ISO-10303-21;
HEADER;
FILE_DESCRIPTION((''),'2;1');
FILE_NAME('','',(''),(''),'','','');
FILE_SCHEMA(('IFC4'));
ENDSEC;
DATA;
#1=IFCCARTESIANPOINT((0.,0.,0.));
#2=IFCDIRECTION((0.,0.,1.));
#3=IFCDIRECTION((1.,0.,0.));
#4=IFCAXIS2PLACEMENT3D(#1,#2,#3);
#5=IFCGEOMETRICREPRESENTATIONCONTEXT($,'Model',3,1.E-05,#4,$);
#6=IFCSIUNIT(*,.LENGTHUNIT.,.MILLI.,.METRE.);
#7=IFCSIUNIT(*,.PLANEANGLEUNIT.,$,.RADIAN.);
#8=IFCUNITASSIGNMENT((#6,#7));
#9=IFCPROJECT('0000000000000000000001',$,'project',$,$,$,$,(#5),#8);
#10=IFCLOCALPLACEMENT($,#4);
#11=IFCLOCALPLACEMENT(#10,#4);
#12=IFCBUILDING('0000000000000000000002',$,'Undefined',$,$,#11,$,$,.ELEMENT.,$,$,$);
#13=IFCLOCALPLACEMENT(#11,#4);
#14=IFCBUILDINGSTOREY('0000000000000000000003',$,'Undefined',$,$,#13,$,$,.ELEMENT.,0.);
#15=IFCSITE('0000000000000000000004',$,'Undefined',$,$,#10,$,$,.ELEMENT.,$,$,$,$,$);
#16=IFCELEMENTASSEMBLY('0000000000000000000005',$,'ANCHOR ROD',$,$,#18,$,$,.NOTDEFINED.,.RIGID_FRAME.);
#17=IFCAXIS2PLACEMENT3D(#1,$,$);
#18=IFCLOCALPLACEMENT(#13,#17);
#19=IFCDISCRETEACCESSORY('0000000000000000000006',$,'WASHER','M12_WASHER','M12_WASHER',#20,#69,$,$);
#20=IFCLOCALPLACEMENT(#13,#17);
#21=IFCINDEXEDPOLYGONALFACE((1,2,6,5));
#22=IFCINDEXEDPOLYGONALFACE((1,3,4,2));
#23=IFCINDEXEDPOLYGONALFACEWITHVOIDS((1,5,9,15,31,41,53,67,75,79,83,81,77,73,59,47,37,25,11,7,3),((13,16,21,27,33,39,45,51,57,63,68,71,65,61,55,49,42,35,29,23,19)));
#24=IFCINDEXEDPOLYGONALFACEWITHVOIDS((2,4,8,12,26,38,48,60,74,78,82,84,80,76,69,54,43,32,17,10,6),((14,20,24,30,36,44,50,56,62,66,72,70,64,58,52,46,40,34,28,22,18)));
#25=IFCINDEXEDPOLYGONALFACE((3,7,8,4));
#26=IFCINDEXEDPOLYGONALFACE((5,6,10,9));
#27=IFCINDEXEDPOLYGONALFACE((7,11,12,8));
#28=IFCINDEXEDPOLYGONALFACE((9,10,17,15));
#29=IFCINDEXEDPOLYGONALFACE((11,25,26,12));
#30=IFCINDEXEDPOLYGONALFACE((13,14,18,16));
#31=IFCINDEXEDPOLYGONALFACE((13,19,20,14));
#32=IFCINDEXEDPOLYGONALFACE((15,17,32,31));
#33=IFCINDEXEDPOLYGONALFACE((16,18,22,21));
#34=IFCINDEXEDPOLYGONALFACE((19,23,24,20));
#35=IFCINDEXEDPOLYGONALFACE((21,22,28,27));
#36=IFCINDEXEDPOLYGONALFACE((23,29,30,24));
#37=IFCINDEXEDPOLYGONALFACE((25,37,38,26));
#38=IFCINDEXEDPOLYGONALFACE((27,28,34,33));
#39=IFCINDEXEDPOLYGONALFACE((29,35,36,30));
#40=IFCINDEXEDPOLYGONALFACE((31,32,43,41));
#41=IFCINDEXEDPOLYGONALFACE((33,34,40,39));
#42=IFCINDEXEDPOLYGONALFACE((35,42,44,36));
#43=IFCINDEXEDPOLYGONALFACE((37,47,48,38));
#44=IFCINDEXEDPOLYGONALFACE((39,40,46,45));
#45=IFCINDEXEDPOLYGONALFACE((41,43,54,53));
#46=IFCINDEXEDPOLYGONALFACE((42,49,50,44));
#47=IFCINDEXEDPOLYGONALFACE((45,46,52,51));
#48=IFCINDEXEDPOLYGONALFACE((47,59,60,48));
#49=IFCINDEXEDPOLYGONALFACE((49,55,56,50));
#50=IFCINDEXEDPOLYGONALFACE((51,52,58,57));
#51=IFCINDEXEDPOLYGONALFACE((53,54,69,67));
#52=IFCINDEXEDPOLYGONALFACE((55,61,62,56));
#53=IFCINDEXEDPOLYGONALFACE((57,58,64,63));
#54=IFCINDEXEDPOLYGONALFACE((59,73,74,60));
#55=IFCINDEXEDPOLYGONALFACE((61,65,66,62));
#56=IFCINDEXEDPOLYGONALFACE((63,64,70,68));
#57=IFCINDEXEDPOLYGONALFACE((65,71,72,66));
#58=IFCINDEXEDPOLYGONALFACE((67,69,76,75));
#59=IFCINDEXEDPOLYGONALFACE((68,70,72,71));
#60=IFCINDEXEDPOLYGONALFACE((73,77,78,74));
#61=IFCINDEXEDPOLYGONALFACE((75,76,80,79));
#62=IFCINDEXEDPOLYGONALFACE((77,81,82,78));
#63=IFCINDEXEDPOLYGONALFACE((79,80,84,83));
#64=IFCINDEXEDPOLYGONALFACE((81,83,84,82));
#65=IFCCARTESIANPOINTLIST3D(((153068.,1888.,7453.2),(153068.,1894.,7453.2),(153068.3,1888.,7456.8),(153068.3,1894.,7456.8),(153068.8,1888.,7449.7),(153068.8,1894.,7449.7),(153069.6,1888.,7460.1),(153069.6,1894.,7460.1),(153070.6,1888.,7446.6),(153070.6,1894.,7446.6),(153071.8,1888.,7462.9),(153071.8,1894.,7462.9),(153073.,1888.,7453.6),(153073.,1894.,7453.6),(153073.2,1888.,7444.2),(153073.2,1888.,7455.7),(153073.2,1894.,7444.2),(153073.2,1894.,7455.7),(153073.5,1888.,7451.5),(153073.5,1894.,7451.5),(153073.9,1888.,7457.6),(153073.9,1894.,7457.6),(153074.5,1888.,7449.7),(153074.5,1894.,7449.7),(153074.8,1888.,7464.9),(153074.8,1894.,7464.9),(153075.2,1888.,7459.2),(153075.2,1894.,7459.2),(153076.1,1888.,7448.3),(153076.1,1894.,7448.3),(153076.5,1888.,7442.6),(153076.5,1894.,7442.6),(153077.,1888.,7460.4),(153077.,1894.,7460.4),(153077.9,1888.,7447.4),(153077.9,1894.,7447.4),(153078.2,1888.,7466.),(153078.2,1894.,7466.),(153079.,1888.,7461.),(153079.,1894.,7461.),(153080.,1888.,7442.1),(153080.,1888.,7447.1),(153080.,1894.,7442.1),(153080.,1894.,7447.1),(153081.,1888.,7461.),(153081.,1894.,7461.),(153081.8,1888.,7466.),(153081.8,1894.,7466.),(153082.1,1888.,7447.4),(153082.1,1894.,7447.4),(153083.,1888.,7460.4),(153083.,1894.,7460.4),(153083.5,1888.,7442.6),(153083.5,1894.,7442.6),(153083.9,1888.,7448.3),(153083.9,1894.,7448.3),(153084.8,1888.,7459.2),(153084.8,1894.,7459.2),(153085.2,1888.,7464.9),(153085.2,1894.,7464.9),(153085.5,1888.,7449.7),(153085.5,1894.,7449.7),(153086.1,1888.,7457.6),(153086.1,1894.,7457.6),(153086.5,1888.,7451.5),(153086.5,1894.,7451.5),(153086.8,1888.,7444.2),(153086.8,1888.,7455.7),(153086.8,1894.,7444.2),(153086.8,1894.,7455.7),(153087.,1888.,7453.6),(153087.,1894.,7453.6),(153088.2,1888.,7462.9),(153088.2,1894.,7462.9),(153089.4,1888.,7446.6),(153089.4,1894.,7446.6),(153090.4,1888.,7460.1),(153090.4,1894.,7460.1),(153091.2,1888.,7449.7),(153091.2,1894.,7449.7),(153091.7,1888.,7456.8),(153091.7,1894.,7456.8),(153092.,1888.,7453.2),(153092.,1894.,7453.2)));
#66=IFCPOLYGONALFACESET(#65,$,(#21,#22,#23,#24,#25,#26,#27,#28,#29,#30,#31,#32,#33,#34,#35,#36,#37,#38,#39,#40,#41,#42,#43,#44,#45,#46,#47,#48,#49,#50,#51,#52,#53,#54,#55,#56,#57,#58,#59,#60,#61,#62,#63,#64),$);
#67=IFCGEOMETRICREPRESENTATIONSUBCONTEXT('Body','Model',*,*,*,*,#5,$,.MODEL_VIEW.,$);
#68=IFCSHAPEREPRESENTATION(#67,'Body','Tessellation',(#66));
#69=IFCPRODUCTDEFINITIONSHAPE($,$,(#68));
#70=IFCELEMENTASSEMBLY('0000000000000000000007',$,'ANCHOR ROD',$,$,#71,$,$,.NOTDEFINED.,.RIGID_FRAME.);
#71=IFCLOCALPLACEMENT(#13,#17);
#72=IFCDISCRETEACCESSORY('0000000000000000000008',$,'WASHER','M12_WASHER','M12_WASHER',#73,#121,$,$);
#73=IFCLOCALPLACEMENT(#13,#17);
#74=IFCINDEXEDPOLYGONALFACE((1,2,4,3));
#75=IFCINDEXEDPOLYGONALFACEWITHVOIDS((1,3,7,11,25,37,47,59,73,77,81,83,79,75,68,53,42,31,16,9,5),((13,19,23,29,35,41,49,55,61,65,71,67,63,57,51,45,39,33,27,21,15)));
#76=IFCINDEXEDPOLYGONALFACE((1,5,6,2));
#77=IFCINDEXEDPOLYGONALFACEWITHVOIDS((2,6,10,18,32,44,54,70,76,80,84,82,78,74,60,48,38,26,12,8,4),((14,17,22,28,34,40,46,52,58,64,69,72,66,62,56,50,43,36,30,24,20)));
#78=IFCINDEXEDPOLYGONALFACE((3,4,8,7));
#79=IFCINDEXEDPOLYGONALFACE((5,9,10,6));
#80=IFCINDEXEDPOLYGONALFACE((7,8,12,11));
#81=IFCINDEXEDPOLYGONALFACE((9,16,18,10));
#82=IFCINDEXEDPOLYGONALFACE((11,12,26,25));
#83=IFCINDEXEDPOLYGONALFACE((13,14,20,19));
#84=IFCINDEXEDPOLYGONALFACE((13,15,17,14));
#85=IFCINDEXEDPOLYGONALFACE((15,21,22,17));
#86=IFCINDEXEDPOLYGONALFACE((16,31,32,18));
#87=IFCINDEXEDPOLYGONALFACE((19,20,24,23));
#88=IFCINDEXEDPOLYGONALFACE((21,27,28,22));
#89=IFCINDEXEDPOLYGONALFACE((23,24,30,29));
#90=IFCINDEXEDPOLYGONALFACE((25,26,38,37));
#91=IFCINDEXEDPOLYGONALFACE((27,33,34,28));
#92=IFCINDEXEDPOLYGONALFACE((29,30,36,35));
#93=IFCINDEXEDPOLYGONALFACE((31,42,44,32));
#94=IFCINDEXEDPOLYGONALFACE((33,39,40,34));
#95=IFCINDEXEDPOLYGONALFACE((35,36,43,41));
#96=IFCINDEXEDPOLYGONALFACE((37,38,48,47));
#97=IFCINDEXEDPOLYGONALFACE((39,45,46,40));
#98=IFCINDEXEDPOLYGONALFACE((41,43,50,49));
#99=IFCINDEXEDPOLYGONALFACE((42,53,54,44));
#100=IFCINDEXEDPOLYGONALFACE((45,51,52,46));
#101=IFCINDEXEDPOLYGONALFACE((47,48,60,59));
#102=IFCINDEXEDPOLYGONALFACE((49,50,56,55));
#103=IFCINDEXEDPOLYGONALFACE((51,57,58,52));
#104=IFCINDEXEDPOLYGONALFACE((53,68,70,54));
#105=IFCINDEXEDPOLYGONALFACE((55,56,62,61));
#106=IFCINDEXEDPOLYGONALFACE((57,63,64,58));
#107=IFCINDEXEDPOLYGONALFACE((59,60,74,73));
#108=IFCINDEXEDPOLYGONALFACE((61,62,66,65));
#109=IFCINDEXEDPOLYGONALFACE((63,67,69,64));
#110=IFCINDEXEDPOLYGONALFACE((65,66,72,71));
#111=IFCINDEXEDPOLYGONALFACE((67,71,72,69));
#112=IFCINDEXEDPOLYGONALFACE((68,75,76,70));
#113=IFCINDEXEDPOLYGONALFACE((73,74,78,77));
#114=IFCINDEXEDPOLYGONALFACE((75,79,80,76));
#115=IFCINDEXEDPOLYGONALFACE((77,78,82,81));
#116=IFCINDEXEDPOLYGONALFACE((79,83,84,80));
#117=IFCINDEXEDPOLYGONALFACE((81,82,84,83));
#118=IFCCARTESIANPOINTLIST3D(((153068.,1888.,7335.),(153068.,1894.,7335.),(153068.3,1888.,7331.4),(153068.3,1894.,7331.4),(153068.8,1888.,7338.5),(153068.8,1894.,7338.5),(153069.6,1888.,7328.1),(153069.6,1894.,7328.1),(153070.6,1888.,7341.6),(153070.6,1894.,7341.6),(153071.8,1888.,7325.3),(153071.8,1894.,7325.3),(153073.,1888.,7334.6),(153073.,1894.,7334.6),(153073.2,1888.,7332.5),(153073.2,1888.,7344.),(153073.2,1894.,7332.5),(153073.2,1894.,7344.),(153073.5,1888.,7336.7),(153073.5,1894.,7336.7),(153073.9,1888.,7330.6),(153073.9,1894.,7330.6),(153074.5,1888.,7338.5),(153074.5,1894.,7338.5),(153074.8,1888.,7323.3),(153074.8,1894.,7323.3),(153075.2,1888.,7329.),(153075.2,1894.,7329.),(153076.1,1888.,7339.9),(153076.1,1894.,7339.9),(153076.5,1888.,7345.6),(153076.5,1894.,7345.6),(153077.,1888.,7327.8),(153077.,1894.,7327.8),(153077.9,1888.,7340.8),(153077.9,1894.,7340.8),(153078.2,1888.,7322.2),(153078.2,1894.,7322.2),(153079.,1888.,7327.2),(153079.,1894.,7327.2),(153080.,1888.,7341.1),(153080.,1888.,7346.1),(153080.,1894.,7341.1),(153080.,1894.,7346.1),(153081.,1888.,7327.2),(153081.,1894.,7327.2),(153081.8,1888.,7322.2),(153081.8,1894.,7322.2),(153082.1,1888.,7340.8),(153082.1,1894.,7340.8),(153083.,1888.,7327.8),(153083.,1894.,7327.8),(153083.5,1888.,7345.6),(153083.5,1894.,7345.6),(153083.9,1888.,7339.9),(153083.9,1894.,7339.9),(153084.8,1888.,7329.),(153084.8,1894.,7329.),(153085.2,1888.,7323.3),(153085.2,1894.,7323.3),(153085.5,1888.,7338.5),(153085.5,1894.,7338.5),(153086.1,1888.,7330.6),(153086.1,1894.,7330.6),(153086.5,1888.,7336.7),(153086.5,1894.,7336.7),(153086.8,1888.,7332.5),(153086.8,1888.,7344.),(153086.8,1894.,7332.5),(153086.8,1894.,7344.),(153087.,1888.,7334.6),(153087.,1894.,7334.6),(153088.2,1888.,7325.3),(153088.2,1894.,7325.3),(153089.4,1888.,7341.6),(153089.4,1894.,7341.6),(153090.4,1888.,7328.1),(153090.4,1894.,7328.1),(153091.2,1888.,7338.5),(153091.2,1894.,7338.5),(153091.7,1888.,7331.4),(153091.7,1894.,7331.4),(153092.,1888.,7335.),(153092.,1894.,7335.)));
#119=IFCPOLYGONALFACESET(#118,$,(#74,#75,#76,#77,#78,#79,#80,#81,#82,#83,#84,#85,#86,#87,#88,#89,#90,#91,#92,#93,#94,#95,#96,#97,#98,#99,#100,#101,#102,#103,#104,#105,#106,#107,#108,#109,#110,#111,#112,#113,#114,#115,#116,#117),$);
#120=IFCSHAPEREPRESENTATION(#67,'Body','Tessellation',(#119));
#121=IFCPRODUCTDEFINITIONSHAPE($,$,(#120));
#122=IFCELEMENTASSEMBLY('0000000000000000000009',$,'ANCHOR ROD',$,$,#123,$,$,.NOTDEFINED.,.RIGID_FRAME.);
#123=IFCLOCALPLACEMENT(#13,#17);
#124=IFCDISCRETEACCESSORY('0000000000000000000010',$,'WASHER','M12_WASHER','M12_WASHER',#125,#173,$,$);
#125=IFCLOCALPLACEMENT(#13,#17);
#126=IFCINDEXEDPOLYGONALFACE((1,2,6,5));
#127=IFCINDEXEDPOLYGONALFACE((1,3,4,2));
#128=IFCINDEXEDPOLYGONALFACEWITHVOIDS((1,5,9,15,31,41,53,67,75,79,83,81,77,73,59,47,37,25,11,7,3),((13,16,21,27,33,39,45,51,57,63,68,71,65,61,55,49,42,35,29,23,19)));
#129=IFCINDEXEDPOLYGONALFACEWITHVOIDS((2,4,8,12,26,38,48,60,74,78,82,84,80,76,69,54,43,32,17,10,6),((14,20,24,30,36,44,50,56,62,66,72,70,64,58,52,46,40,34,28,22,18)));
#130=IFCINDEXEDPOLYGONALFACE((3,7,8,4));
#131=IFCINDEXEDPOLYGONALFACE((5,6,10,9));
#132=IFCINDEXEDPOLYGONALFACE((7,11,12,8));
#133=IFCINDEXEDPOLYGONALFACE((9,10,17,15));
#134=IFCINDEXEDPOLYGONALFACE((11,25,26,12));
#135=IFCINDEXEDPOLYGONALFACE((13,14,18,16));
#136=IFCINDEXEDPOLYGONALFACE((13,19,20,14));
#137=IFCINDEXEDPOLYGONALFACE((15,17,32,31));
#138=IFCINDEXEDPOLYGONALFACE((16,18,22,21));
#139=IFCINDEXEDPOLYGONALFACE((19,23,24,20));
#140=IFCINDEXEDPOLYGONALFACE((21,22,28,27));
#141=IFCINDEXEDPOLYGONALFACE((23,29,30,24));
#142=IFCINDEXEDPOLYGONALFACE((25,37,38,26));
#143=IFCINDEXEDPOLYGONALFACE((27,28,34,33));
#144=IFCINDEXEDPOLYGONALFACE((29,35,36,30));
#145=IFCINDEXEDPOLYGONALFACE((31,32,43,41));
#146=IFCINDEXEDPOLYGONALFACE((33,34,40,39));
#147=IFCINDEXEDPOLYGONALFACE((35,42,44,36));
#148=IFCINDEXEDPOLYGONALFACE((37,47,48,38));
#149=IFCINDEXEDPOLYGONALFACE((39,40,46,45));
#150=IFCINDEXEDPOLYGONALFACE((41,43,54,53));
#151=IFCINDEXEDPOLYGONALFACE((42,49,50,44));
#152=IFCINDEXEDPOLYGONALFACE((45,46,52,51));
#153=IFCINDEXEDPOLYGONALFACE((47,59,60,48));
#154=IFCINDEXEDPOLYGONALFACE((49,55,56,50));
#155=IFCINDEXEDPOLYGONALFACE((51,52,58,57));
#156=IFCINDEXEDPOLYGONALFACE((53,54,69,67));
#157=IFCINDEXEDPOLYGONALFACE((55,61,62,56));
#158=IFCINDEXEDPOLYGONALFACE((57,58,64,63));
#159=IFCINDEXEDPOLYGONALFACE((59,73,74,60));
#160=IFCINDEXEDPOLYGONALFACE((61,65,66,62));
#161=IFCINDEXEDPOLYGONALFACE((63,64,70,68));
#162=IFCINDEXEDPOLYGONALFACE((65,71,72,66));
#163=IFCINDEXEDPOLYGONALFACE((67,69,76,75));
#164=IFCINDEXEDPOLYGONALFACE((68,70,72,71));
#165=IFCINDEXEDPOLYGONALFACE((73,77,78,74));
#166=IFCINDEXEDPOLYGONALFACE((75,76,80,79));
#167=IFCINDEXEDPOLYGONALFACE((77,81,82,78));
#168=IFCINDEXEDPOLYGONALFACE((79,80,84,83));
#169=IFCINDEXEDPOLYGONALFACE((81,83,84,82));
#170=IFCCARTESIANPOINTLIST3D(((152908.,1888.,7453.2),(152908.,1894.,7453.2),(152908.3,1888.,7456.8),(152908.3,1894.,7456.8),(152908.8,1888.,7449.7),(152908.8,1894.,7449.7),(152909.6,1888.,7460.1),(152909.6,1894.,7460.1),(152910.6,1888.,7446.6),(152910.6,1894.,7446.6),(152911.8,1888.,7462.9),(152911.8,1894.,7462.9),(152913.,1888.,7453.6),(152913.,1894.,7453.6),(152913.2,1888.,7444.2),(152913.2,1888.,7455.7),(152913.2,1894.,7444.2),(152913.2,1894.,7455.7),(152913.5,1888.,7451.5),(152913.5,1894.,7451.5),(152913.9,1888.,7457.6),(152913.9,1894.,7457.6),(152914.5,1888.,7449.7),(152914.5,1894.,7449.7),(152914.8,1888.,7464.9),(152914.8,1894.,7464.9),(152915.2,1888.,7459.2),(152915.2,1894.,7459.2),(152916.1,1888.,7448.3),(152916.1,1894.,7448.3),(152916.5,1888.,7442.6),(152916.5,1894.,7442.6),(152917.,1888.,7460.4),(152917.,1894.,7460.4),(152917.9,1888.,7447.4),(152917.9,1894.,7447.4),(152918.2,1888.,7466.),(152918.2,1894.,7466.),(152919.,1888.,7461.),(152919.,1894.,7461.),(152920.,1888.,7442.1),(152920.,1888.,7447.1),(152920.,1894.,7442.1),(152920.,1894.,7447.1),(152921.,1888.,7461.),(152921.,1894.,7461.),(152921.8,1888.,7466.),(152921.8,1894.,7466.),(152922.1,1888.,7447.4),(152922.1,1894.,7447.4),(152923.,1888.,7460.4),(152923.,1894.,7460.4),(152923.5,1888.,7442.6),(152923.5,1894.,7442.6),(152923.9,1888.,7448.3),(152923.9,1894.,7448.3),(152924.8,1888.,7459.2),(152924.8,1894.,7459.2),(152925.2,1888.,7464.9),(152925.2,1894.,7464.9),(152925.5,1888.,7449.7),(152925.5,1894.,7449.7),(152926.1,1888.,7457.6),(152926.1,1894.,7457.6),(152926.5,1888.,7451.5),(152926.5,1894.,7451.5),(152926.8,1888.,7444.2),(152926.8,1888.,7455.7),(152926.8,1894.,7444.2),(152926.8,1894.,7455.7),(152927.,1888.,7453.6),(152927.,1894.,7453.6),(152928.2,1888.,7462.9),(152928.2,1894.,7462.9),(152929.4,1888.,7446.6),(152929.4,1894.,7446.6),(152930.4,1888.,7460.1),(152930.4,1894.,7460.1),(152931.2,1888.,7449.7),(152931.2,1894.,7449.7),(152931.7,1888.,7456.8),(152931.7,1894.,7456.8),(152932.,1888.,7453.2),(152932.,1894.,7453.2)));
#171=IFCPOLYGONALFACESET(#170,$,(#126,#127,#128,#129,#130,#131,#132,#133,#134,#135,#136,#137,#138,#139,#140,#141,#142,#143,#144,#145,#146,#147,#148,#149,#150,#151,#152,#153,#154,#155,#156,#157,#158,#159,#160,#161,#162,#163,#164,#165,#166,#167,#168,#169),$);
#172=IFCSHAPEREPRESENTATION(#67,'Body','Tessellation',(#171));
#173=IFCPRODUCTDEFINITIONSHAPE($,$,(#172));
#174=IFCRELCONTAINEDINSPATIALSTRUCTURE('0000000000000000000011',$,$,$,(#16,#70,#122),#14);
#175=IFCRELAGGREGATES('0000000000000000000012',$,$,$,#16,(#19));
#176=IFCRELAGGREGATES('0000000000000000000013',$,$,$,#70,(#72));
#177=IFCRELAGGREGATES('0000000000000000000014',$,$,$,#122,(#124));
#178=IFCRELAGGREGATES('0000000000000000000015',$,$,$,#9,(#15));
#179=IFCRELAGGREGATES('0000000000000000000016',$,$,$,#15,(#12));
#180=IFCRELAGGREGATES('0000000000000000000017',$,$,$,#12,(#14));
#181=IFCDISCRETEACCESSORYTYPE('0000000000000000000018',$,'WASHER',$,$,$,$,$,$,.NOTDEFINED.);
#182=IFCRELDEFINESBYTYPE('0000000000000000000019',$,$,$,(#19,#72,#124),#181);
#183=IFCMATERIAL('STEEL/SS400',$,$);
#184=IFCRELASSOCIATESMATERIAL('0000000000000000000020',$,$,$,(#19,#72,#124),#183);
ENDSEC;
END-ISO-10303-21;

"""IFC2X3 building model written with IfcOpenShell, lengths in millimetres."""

from ifc_helpers import new_model, si_unit, frame, origin_with_axes, origin_2d_with_axis, place, context, subcontext, project, spatial, hollow_circle, extrude, material, type_object, element, aggregate, save


model = new_model("IFC2X3")

# Units and contexts
model_context = context("Model", 3, precision=1e-05, world=origin_with_axes())
body_context = subcontext(model_context, "Body", "Model", "MODEL_VIEW")
ifc_project = project(units=[si_unit("LENGTHUNIT", "METRE", prefix="MILLI"), si_unit("PLANEANGLEUNIT", "RADIAN")], contexts=[model_context])

# Site, building, storey
site_placement = place(None, origin_with_axes())
site = spatial("IfcSite", under=ifc_project, at=site_placement, Name="Undefined", CompositionType="ELEMENT")
building_placement = place(site_placement, origin_with_axes())
building = spatial("IfcBuilding", under=site, at=building_placement, Name="Undefined", CompositionType="ELEMENT")
storey_placement = place(building_placement, origin_with_axes())
storey = spatial("IfcBuildingStorey", under=building, at=storey_placement, Name="Undefined", CompositionType="ELEMENT", Elevation=0.0)

# Shared definitions
ifc_material_1 = material(Name="STEEL/SS400")

# Element assemblies, discrete accessories
assembly_1_placement = place(storey_placement, origin_with_axes())
assembly_1 = element("IfcElementAssembly", 1, at=assembly_1_placement, inside=storey, Name="ANCHOR ROD", AssemblyPlace="NOTDEFINED", PredefinedType="RIGID_FRAME")
discrete_accessory_type_1 = type_object("IfcDiscreteAccessoryType", Name="WASHER")
discrete_accessory_1_placement = place(assembly_1_placement, frame((153080.0, 1888.0, 7454.1), z_axis=(1.0, 0.0, 0.0), x_axis=(0.0, 1.0, 0.0)))
discrete_accessory_1 = element("IfcDiscreteAccessory", 2, at=discrete_accessory_1_placement, type_object=discrete_accessory_type_1, material=ifc_material_1, Name="WASHER", Description="M12_WASHER", ObjectType="M12_WASHER", context=body_context, shape_type="SweptSolid", body=[
    extrude(hollow_circle(Radius=12.0, WallThickness=5.0, at=origin_2d_with_axis()), frame((6.0, 0.0, 0.0), z_axis=(-1.0, 0.0, 0.0), x_axis=(0.0, -1.0, 0.0)), (0.0, 0.0, 1.0), 6.0),
])
aggregate(assembly_1, [discrete_accessory_1])
assembly_2_placement = place(storey_placement, origin_with_axes())
assembly_2 = element("IfcElementAssembly", 3, at=assembly_2_placement, inside=storey, Name="ANCHOR ROD", AssemblyPlace="NOTDEFINED", PredefinedType="RIGID_FRAME")
discrete_accessory_2_placement = place(assembly_2_placement, frame((153080.0, 1888.0, 7334.1), z_axis=(-1.0, 0.0, 0.0), x_axis=(0.0, 1.0, 0.0)))
discrete_accessory_2 = element("IfcDiscreteAccessory", 4, at=discrete_accessory_2_placement, type_object=discrete_accessory_type_1, material=ifc_material_1, Name="WASHER", Description="M12_WASHER", ObjectType="M12_WASHER", context=body_context, shape_type="SweptSolid", body=[
    extrude(hollow_circle(Radius=12.0, WallThickness=5.0, at=origin_2d_with_axis()), frame((6.0, 0.0, 0.0), z_axis=(-1.0, 0.0, 0.0), x_axis=(0.0, -1.0, 0.0)), (0.0, 0.0, 1.0), 6.0),
])
aggregate(assembly_2, [discrete_accessory_2])
assembly_3_placement = place(storey_placement, origin_with_axes())
assembly_3 = element("IfcElementAssembly", 5, at=assembly_3_placement, inside=storey, Name="ANCHOR ROD", AssemblyPlace="NOTDEFINED", PredefinedType="RIGID_FRAME")
discrete_accessory_3_placement = place(assembly_3_placement, frame((152920.0, 1888.0, 7454.1), z_axis=(1.0, 0.0, 0.0), x_axis=(0.0, 1.0, 0.0)))
discrete_accessory_3 = element("IfcDiscreteAccessory", 6, at=discrete_accessory_3_placement, type_object=discrete_accessory_type_1, material=ifc_material_1, Name="WASHER", Description="M12_WASHER", ObjectType="M12_WASHER", context=body_context, shape_type="SweptSolid", body=[
    extrude(hollow_circle(Radius=12.0, WallThickness=5.0, at=origin_2d_with_axis()), frame((6.0, 0.0, 0.0), z_axis=(-1.0, 0.0, 0.0), x_axis=(0.0, -1.0, 0.0)), (0.0, 0.0, 1.0), 6.0),
])
aggregate(assembly_3, [discrete_accessory_3])

save(model, "model.ifc")
